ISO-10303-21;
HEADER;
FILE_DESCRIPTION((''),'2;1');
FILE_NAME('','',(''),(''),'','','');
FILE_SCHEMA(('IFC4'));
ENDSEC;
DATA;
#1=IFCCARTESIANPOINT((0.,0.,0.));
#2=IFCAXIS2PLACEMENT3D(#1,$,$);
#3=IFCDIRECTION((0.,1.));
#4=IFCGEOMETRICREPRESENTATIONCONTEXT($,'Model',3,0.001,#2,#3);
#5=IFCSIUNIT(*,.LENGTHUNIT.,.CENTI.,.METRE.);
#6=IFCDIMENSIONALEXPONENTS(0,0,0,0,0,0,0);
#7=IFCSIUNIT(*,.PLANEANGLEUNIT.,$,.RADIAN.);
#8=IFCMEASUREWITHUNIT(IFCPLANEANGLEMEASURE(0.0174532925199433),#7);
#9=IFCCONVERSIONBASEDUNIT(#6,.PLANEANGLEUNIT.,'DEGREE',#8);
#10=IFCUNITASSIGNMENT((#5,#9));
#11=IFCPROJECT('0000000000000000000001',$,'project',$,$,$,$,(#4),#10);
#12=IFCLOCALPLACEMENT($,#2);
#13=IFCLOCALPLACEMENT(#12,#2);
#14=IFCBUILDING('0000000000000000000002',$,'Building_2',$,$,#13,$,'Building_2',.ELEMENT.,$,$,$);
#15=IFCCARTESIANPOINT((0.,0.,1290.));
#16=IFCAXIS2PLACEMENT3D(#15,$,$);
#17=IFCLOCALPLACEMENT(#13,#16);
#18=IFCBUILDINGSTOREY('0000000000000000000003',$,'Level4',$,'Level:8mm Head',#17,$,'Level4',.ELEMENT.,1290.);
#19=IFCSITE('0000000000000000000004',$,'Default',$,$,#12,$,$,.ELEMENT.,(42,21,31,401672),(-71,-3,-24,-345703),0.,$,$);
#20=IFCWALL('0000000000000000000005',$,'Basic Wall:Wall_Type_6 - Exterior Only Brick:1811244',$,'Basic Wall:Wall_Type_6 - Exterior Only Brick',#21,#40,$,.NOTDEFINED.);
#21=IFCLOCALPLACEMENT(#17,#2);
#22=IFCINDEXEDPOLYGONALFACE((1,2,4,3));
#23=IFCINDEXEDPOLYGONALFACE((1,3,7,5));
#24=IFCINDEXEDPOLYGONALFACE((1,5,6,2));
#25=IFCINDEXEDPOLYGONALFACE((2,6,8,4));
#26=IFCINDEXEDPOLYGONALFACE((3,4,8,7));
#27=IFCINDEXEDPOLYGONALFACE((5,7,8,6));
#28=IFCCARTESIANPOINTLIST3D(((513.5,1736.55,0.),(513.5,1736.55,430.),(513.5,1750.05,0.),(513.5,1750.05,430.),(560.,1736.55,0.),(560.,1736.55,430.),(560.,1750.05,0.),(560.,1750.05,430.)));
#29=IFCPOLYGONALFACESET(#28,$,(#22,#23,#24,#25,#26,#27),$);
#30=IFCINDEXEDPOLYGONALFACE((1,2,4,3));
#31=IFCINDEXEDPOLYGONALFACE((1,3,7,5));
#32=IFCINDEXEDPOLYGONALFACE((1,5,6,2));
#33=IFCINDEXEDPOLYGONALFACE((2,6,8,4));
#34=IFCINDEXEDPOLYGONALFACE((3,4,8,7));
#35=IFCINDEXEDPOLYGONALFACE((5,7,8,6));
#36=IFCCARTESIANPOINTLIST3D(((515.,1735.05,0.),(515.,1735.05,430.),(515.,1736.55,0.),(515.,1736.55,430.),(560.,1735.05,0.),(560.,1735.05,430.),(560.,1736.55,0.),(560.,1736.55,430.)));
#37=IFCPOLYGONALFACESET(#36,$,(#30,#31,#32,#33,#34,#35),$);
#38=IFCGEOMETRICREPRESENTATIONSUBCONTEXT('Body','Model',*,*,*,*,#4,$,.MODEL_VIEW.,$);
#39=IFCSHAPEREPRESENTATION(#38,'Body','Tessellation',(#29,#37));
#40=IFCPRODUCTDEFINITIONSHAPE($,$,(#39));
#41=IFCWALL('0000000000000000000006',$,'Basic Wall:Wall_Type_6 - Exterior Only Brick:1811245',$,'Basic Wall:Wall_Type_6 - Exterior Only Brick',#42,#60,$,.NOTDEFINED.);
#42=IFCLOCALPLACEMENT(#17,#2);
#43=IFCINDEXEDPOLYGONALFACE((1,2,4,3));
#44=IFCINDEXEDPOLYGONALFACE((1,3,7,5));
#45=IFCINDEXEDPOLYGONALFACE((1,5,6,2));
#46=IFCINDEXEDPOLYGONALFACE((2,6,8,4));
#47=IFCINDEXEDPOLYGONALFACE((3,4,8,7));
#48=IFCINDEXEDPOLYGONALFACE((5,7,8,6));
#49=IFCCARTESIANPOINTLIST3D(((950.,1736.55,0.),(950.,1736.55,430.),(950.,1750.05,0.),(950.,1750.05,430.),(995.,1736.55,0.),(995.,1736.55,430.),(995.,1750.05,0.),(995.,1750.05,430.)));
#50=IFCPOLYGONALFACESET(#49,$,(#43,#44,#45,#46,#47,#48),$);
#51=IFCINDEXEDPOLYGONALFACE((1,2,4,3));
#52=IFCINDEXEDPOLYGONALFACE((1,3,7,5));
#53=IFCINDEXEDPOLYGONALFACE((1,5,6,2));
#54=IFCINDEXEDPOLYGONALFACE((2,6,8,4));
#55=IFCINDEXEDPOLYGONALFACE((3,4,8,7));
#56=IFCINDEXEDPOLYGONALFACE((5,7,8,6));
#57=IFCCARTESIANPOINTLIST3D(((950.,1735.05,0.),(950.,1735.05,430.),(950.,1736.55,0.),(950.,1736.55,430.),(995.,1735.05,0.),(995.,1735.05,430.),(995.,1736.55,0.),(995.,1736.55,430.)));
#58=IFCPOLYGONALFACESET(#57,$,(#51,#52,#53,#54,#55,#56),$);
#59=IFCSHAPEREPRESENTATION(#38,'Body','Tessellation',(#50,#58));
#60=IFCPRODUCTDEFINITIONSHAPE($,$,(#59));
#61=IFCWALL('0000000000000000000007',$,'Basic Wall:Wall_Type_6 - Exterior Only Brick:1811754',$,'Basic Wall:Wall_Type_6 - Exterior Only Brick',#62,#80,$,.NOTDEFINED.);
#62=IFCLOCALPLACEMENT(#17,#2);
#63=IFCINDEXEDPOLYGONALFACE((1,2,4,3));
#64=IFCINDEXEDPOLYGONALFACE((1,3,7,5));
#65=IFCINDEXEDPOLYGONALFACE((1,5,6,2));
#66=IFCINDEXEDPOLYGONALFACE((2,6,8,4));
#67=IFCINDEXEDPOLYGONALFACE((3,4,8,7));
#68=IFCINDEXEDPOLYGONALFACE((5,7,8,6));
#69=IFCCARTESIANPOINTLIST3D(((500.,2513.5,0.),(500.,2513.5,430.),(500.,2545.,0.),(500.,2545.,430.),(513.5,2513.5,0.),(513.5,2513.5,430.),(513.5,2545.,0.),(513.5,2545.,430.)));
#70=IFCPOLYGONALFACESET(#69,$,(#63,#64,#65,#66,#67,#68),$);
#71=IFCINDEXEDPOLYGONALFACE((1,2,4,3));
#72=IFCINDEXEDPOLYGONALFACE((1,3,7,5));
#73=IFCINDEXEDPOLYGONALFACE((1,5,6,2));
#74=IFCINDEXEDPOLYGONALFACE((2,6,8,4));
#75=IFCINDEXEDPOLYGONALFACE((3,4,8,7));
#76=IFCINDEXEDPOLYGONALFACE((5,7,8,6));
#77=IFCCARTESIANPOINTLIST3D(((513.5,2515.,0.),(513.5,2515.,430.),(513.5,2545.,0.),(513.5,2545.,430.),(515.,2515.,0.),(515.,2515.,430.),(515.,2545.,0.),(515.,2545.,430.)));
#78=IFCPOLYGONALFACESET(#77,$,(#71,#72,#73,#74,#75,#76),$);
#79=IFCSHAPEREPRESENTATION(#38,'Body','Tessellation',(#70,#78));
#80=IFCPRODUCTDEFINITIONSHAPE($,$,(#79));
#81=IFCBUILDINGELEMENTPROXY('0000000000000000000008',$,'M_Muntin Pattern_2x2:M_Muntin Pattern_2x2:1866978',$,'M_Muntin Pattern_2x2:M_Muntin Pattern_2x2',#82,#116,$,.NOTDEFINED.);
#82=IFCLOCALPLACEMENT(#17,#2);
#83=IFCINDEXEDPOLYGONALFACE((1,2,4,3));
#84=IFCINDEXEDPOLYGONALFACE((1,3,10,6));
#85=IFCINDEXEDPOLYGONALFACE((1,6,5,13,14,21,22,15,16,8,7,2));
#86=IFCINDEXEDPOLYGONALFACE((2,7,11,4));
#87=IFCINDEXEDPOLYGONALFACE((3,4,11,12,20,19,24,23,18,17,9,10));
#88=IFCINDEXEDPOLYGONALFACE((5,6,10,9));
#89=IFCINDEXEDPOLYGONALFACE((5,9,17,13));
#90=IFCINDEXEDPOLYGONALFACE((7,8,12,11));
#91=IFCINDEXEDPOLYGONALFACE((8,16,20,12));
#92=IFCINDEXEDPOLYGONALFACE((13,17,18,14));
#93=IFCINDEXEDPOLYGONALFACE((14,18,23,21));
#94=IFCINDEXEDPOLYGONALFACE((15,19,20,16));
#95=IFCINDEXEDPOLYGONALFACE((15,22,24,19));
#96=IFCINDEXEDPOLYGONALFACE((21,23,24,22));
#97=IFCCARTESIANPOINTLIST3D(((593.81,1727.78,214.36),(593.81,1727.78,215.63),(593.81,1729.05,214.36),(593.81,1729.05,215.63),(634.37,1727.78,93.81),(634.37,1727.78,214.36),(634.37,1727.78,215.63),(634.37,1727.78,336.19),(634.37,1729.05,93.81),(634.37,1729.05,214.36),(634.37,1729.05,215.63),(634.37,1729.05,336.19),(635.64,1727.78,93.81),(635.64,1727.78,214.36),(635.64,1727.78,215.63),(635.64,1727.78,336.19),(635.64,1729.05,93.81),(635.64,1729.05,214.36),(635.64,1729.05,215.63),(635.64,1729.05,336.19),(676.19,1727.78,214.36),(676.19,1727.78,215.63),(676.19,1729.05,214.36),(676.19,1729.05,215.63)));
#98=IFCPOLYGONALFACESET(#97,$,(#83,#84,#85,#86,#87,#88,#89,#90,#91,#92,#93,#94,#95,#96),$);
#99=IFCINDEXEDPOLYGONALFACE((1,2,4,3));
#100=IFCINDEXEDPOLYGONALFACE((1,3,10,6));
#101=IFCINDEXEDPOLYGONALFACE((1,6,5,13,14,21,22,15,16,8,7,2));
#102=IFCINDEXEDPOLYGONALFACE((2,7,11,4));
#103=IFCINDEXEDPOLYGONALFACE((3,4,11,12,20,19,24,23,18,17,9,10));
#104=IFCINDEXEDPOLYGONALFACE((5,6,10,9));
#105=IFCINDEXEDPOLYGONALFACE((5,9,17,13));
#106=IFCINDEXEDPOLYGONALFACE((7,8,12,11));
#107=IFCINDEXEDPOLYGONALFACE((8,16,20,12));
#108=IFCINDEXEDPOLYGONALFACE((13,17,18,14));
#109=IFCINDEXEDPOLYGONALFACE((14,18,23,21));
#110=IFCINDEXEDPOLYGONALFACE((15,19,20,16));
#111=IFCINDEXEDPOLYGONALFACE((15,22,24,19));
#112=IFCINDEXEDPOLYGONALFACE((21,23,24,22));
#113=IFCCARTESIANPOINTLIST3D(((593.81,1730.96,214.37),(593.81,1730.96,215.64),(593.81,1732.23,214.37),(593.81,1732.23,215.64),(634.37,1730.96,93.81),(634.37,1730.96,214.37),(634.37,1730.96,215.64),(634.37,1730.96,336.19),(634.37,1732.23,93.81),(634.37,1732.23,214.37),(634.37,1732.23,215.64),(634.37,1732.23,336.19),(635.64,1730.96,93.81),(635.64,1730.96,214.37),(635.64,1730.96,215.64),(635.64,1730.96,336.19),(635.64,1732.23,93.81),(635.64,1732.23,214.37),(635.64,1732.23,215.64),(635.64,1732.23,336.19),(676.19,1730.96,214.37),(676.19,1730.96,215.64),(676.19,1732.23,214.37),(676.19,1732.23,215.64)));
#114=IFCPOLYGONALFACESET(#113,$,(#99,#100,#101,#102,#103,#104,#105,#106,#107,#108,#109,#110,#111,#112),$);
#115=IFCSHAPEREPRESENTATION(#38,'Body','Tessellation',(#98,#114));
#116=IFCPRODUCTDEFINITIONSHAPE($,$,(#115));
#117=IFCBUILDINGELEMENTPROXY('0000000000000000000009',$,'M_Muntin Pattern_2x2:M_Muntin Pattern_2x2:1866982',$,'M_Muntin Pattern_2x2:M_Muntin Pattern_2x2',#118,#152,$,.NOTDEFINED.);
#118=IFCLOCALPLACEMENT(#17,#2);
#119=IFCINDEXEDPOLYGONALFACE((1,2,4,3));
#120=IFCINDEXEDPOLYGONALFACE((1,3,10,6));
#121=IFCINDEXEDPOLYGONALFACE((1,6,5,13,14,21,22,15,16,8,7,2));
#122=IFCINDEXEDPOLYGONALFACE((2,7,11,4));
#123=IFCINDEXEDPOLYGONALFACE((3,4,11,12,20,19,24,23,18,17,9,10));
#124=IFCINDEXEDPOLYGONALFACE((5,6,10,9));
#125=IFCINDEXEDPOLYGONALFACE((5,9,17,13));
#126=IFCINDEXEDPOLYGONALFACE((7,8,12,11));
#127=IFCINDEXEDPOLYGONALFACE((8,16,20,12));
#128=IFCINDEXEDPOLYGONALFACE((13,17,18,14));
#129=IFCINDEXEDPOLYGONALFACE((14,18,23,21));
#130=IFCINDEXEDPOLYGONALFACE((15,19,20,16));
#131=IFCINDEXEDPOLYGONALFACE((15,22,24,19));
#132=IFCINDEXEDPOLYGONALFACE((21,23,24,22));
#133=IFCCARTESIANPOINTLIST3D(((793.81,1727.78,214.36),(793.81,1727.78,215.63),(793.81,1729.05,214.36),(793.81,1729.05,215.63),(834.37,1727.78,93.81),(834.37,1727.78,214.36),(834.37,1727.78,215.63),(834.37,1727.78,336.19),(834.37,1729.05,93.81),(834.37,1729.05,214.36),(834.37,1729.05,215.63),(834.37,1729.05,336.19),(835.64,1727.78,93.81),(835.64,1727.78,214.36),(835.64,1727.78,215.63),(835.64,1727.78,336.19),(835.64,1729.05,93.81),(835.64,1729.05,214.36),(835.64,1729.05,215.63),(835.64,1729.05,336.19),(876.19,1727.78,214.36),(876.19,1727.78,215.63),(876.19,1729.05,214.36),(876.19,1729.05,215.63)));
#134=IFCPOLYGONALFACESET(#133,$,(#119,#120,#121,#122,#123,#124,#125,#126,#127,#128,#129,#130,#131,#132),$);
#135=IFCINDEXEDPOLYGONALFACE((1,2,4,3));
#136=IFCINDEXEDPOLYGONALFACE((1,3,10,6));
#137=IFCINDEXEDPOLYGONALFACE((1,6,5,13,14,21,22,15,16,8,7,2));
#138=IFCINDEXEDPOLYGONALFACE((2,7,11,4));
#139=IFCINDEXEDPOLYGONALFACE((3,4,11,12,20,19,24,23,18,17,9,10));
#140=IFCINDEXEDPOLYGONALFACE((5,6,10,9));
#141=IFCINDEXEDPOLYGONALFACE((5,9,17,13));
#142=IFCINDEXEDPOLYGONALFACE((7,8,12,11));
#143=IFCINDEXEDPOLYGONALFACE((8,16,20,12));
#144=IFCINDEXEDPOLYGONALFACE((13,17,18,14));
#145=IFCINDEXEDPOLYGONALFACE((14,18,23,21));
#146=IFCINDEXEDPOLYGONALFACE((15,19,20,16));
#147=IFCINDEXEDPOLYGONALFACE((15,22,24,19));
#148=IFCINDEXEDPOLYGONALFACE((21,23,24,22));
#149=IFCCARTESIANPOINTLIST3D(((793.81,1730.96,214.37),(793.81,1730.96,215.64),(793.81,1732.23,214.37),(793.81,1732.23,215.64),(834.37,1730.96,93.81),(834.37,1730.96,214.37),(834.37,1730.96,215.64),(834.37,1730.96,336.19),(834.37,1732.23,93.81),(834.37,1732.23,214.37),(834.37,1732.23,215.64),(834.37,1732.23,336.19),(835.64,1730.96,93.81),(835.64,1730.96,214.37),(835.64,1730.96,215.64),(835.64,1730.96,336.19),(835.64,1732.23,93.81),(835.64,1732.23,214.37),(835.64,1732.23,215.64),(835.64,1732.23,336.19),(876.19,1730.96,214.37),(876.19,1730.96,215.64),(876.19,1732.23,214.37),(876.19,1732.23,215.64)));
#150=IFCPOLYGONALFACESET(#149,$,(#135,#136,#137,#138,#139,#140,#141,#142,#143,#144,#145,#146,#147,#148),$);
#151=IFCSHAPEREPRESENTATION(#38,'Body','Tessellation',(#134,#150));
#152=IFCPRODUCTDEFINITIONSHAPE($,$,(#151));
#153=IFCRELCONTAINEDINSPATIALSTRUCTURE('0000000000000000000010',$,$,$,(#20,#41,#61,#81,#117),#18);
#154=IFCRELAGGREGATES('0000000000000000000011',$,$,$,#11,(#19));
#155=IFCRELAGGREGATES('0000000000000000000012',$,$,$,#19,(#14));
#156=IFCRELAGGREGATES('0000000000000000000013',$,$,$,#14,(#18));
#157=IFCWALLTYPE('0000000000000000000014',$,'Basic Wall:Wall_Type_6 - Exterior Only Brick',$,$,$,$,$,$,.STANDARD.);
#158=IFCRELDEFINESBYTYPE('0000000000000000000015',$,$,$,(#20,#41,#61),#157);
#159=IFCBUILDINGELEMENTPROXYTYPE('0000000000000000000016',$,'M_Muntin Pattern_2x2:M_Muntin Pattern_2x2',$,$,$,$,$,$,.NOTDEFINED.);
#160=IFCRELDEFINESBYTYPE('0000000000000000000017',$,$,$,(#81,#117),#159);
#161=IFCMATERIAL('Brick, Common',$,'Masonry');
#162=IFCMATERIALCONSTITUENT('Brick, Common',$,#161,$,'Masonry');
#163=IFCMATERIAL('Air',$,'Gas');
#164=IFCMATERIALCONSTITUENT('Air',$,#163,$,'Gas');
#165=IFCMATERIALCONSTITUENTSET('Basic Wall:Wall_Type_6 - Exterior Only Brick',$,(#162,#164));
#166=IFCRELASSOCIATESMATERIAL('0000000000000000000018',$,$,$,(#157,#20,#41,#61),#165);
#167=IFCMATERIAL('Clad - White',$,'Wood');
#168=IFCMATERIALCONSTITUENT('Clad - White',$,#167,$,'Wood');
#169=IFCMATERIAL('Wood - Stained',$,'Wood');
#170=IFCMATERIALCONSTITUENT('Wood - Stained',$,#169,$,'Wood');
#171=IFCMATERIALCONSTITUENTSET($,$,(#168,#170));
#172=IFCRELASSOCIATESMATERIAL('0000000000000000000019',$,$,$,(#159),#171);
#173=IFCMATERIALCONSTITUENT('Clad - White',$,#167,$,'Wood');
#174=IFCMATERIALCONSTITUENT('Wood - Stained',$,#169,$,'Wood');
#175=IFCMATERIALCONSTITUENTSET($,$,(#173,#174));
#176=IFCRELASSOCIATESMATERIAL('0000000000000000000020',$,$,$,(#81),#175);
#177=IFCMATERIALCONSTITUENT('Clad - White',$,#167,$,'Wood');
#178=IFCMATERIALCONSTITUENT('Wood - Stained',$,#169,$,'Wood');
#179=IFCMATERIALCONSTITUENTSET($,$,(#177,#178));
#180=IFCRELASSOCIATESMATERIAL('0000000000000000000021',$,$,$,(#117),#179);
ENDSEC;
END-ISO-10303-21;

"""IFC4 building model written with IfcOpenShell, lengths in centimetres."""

from ifc_helpers import new_model, entity, si_unit, converted_unit, direction, frame, origin, place, context, subcontext, project, spatial, indexed_curve, outline, extrude, source, transform, mapped, material, constituent, constituent_set, type_object, type_shapes, element, save


model = new_model("IFC4")

# Units and contexts
model_context = context("Model", 3, precision=0.001, world=origin(), true_north=direction((0.0, 1.0)))
body_context = subcontext(model_context, "Body", "Model", "MODEL_VIEW")
ifc_project = project(units=[si_unit("LENGTHUNIT", "METRE", prefix="CENTI"), converted_unit("PLANEANGLEUNIT", "DEGREE", entity("IfcPlaneAngleMeasure", 0.0174532925199433), si_unit("PLANEANGLEUNIT", "RADIAN"), dimensions=[0, 0, 0, 0, 0, 0, 0])], contexts=[model_context])

# Site, building, storey
site_placement = place(None, origin())
site = spatial("IfcSite", under=ifc_project, at=site_placement, Name="Default", CompositionType="ELEMENT", RefLatitude=(42, 21, 31, 401672), RefLongitude=(-71, -3, -24, -345703), RefElevation=0.0)
building_placement = place(site_placement, origin())
building = spatial("IfcBuilding", under=site, at=building_placement, Name="Building_2", LongName="Building_2", CompositionType="ELEMENT")
storey_placement = place(building_placement, frame((0.0, 0.0, 1290.0)))
storey = spatial("IfcBuildingStorey", under=building, at=storey_placement, Name="Level4", ObjectType="Level:8mm Head", LongName="Level4", CompositionType="ELEMENT", Elevation=1290.0)

# Shared definitions
ifc_material_1 = material(Name="Brick, Common", Category="Masonry")
ifc_material_2 = material(Name="Air", Category="Gas")

# Walls
ifc_constituent_1 = constituent(ifc_material_1, Name="Brick, Common", Category="Masonry")
ifc_constituent_2 = constituent(ifc_material_2, Name="Air", Category="Gas")
ifc_constituent_set_1 = constituent_set(constituents=[ifc_constituent_1, ifc_constituent_2], Name="Basic Wall:Wall_Type_6 - Exterior Only Brick")
wall_type_1 = type_object("IfcWallType", Name="Basic Wall:Wall_Type_6 - Exterior Only Brick", PredefinedType="STANDARD", material=ifc_constituent_set_1)
wall_1_placement = place(storey_placement, frame((515.0, 1742.55, 0.0)))
element("IfcWall", 1, at=wall_1_placement, inside=storey, type_object=wall_type_1, material=ifc_constituent_set_1, Name="Basic Wall:Wall_Type_6 - Exterior Only Brick:1811244", ObjectType="Basic Wall:Wall_Type_6 - Exterior Only Brick", PredefinedType="NOTDEFINED", context=body_context, shape_type="SweptSolid", body=[
    extrude(outline(indexed_curve([(-6.75, -23.25), (6.75, -23.25), (6.75, 23.25), (-6.75, 23.25), (-6.75, -23.25)], self_intersect=False)), frame((21.75, 0.75, 0.0), z_axis=(0.0, 0.0, 1.0), x_axis=(0.0, -1.0, 0.0)), (0.0, 0.0, 1.0), 430.0),
    extrude(outline(indexed_curve([(-0.75, -22.5), (0.75, -22.5), (0.75, 22.5), (-0.75, 22.5), (-0.75, -22.5)], self_intersect=False)), frame((22.5, -6.75, 0.0), z_axis=(0.0, 0.0, 1.0), x_axis=(0.0, 1.0, 0.0)), (0.0, 0.0, 1.0), 430.0),
])
wall_2_placement = place(storey_placement, frame((950.0, 1742.55, 0.0)))
element("IfcWall", 2, at=wall_2_placement, inside=storey, type_object=wall_type_1, material=ifc_constituent_set_1, Name="Basic Wall:Wall_Type_6 - Exterior Only Brick:1811245", ObjectType="Basic Wall:Wall_Type_6 - Exterior Only Brick", PredefinedType="NOTDEFINED", context=body_context, shape_type="SweptSolid", body=[
    extrude(outline(indexed_curve([(-6.75, -22.5), (6.75, -22.5), (6.75, 22.5), (-6.75, 22.5), (-6.75, -22.5)], self_intersect=False)), frame((22.5, 0.75, 0.0), z_axis=(0.0, 0.0, 1.0), x_axis=(0.0, -1.0, 0.0)), (0.0, 0.0, 1.0), 430.0),
    extrude(outline(indexed_curve([(-0.75, -22.5), (0.75, -22.5), (0.75, 22.5), (-0.75, 22.5), (-0.75, -22.5)], self_intersect=False)), frame((22.5, -6.75, 0.0), z_axis=(0.0, 0.0, 1.0), x_axis=(0.0, 1.0, 0.0)), (0.0, 0.0, 1.0), 430.0),
])
wall_3_placement = place(storey_placement, frame((507.5, 2545.0, 0.0), z_axis=(0.0, 0.0, 1.0), x_axis=(0.0, -1.0, 0.0)))
element("IfcWall", 3, at=wall_3_placement, inside=storey, type_object=wall_type_1, material=ifc_constituent_set_1, Name="Basic Wall:Wall_Type_6 - Exterior Only Brick:1811754", ObjectType="Basic Wall:Wall_Type_6 - Exterior Only Brick", PredefinedType="NOTDEFINED", context=body_context, shape_type="SweptSolid", body=[
    extrude(outline(indexed_curve([(-6.75, -15.75), (6.75, -15.75), (6.75, 15.75), (-6.75, 15.75), (-6.75, -15.75)], self_intersect=False)), frame((15.75, -0.75, 0.0), z_axis=(0.0, 0.0, 1.0), x_axis=(0.0, 1.0, 0.0)), (0.0, 0.0, 1.0), 430.0),
    extrude(outline(indexed_curve([(-0.75, -15.0), (0.75, -15.0), (0.75, 15.0), (-0.75, 15.0), (-0.75, -15.0)], self_intersect=False)), frame((15.0, 6.75, 0.0), z_axis=(0.0, 0.0, 1.0), x_axis=(0.0, -1.0, 0.0)), (0.0, 0.0, 1.0), 430.0),
])

# Building element proxies
ifc_material_3 = material(Name="Clad - White", Category="Wood")
ifc_constituent_3 = constituent(ifc_material_3, Name="Clad - White", Category="Wood")
ifc_material_4 = material(Name="Wood - Stained", Category="Wood")
ifc_constituent_4 = constituent(ifc_material_4, Name="Wood - Stained", Category="Wood")
ifc_constituent_set_2 = constituent_set(constituents=[ifc_constituent_3, ifc_constituent_4])
ifc_constituent_5 = constituent(ifc_material_3, Name="Clad - White", Category="Wood")
ifc_constituent_6 = constituent(ifc_material_4, Name="Wood - Stained", Category="Wood")
ifc_constituent_set_3 = constituent_set(constituents=[ifc_constituent_5, ifc_constituent_6])
building_element_proxy_type_1 = type_object("IfcBuildingElementProxyType", Name="M_Muntin Pattern_2x2:M_Muntin Pattern_2x2", PredefinedType="NOTDEFINED", material=ifc_constituent_set_3)
shared_shape_1 = source(origin(), body_context, "Body", "SweptSolid", [
    extrude(outline(indexed_curve([(0.64, -0.64), (121.19, -0.64), (121.19, 0.63), (0.64, 0.63), (0.64, 41.19), (-0.63, 41.19), (-0.63, 0.63), (-121.19, 0.63), (-121.19, -0.64), (-0.63, -0.64), (-0.63, -41.19), (0.64, -41.19), (0.64, -0.64)], self_intersect=False)), frame((0.0, 0.95, 121.19), z_axis=(0.0, 1.0, 0.0), x_axis=(0.0, 0.0, 1.0)), (0.0, 0.0, 1.0), 1.27),
    extrude(outline(indexed_curve([(0.64, -0.64), (121.19, -0.64), (121.19, 0.63), (0.64, 0.63), (0.64, 41.19), (-0.63, 41.19), (-0.63, 0.63), (-121.19, 0.63), (-121.19, -0.64), (-0.63, -0.64), (-0.63, -41.19), (0.64, -41.19), (0.64, -0.64)], self_intersect=False)), frame((0.0, -2.22, 121.19), z_axis=(0.0, 1.0, 0.0), x_axis=(0.0, 0.0, 1.0)), (0.0, 0.0, 1.0), 1.27),
])
type_shapes(building_element_proxy_type_1, [shared_shape_1])
proxy_1_placement = place(storey_placement, frame((635.0, 1730.0, 93.81), z_axis=(0.0, 0.0, 1.0), x_axis=(-1.0, 0.0, 0.0)))
element("IfcBuildingElementProxy", 4, at=proxy_1_placement, inside=storey, type_object=building_element_proxy_type_1, material=ifc_constituent_set_2, Name="M_Muntin Pattern_2x2:M_Muntin Pattern_2x2:1866978", ObjectType="M_Muntin Pattern_2x2:M_Muntin Pattern_2x2", PredefinedType="NOTDEFINED", context=body_context, shape_type="MappedRepresentation", body=[
    mapped(shared_shape_1, transform((0.0, 0.0, 0.0), scale=1.0)),
])
ifc_constituent_7 = constituent(ifc_material_3, Name="Clad - White", Category="Wood")
ifc_constituent_8 = constituent(ifc_material_4, Name="Wood - Stained", Category="Wood")
ifc_constituent_set_4 = constituent_set(constituents=[ifc_constituent_7, ifc_constituent_8])
proxy_2_placement = place(storey_placement, frame((835.0, 1730.0, 93.81), z_axis=(0.0, 0.0, 1.0), x_axis=(-1.0, 0.0, 0.0)))
element("IfcBuildingElementProxy", 5, at=proxy_2_placement, inside=storey, type_object=building_element_proxy_type_1, material=ifc_constituent_set_4, Name="M_Muntin Pattern_2x2:M_Muntin Pattern_2x2:1866982", ObjectType="M_Muntin Pattern_2x2:M_Muntin Pattern_2x2", PredefinedType="NOTDEFINED", context=body_context, shape_type="MappedRepresentation", body=[
    mapped(shared_shape_1, transform((0.0, 0.0, 0.0), scale=1.0)),
])

save(model, "model.ifc")
